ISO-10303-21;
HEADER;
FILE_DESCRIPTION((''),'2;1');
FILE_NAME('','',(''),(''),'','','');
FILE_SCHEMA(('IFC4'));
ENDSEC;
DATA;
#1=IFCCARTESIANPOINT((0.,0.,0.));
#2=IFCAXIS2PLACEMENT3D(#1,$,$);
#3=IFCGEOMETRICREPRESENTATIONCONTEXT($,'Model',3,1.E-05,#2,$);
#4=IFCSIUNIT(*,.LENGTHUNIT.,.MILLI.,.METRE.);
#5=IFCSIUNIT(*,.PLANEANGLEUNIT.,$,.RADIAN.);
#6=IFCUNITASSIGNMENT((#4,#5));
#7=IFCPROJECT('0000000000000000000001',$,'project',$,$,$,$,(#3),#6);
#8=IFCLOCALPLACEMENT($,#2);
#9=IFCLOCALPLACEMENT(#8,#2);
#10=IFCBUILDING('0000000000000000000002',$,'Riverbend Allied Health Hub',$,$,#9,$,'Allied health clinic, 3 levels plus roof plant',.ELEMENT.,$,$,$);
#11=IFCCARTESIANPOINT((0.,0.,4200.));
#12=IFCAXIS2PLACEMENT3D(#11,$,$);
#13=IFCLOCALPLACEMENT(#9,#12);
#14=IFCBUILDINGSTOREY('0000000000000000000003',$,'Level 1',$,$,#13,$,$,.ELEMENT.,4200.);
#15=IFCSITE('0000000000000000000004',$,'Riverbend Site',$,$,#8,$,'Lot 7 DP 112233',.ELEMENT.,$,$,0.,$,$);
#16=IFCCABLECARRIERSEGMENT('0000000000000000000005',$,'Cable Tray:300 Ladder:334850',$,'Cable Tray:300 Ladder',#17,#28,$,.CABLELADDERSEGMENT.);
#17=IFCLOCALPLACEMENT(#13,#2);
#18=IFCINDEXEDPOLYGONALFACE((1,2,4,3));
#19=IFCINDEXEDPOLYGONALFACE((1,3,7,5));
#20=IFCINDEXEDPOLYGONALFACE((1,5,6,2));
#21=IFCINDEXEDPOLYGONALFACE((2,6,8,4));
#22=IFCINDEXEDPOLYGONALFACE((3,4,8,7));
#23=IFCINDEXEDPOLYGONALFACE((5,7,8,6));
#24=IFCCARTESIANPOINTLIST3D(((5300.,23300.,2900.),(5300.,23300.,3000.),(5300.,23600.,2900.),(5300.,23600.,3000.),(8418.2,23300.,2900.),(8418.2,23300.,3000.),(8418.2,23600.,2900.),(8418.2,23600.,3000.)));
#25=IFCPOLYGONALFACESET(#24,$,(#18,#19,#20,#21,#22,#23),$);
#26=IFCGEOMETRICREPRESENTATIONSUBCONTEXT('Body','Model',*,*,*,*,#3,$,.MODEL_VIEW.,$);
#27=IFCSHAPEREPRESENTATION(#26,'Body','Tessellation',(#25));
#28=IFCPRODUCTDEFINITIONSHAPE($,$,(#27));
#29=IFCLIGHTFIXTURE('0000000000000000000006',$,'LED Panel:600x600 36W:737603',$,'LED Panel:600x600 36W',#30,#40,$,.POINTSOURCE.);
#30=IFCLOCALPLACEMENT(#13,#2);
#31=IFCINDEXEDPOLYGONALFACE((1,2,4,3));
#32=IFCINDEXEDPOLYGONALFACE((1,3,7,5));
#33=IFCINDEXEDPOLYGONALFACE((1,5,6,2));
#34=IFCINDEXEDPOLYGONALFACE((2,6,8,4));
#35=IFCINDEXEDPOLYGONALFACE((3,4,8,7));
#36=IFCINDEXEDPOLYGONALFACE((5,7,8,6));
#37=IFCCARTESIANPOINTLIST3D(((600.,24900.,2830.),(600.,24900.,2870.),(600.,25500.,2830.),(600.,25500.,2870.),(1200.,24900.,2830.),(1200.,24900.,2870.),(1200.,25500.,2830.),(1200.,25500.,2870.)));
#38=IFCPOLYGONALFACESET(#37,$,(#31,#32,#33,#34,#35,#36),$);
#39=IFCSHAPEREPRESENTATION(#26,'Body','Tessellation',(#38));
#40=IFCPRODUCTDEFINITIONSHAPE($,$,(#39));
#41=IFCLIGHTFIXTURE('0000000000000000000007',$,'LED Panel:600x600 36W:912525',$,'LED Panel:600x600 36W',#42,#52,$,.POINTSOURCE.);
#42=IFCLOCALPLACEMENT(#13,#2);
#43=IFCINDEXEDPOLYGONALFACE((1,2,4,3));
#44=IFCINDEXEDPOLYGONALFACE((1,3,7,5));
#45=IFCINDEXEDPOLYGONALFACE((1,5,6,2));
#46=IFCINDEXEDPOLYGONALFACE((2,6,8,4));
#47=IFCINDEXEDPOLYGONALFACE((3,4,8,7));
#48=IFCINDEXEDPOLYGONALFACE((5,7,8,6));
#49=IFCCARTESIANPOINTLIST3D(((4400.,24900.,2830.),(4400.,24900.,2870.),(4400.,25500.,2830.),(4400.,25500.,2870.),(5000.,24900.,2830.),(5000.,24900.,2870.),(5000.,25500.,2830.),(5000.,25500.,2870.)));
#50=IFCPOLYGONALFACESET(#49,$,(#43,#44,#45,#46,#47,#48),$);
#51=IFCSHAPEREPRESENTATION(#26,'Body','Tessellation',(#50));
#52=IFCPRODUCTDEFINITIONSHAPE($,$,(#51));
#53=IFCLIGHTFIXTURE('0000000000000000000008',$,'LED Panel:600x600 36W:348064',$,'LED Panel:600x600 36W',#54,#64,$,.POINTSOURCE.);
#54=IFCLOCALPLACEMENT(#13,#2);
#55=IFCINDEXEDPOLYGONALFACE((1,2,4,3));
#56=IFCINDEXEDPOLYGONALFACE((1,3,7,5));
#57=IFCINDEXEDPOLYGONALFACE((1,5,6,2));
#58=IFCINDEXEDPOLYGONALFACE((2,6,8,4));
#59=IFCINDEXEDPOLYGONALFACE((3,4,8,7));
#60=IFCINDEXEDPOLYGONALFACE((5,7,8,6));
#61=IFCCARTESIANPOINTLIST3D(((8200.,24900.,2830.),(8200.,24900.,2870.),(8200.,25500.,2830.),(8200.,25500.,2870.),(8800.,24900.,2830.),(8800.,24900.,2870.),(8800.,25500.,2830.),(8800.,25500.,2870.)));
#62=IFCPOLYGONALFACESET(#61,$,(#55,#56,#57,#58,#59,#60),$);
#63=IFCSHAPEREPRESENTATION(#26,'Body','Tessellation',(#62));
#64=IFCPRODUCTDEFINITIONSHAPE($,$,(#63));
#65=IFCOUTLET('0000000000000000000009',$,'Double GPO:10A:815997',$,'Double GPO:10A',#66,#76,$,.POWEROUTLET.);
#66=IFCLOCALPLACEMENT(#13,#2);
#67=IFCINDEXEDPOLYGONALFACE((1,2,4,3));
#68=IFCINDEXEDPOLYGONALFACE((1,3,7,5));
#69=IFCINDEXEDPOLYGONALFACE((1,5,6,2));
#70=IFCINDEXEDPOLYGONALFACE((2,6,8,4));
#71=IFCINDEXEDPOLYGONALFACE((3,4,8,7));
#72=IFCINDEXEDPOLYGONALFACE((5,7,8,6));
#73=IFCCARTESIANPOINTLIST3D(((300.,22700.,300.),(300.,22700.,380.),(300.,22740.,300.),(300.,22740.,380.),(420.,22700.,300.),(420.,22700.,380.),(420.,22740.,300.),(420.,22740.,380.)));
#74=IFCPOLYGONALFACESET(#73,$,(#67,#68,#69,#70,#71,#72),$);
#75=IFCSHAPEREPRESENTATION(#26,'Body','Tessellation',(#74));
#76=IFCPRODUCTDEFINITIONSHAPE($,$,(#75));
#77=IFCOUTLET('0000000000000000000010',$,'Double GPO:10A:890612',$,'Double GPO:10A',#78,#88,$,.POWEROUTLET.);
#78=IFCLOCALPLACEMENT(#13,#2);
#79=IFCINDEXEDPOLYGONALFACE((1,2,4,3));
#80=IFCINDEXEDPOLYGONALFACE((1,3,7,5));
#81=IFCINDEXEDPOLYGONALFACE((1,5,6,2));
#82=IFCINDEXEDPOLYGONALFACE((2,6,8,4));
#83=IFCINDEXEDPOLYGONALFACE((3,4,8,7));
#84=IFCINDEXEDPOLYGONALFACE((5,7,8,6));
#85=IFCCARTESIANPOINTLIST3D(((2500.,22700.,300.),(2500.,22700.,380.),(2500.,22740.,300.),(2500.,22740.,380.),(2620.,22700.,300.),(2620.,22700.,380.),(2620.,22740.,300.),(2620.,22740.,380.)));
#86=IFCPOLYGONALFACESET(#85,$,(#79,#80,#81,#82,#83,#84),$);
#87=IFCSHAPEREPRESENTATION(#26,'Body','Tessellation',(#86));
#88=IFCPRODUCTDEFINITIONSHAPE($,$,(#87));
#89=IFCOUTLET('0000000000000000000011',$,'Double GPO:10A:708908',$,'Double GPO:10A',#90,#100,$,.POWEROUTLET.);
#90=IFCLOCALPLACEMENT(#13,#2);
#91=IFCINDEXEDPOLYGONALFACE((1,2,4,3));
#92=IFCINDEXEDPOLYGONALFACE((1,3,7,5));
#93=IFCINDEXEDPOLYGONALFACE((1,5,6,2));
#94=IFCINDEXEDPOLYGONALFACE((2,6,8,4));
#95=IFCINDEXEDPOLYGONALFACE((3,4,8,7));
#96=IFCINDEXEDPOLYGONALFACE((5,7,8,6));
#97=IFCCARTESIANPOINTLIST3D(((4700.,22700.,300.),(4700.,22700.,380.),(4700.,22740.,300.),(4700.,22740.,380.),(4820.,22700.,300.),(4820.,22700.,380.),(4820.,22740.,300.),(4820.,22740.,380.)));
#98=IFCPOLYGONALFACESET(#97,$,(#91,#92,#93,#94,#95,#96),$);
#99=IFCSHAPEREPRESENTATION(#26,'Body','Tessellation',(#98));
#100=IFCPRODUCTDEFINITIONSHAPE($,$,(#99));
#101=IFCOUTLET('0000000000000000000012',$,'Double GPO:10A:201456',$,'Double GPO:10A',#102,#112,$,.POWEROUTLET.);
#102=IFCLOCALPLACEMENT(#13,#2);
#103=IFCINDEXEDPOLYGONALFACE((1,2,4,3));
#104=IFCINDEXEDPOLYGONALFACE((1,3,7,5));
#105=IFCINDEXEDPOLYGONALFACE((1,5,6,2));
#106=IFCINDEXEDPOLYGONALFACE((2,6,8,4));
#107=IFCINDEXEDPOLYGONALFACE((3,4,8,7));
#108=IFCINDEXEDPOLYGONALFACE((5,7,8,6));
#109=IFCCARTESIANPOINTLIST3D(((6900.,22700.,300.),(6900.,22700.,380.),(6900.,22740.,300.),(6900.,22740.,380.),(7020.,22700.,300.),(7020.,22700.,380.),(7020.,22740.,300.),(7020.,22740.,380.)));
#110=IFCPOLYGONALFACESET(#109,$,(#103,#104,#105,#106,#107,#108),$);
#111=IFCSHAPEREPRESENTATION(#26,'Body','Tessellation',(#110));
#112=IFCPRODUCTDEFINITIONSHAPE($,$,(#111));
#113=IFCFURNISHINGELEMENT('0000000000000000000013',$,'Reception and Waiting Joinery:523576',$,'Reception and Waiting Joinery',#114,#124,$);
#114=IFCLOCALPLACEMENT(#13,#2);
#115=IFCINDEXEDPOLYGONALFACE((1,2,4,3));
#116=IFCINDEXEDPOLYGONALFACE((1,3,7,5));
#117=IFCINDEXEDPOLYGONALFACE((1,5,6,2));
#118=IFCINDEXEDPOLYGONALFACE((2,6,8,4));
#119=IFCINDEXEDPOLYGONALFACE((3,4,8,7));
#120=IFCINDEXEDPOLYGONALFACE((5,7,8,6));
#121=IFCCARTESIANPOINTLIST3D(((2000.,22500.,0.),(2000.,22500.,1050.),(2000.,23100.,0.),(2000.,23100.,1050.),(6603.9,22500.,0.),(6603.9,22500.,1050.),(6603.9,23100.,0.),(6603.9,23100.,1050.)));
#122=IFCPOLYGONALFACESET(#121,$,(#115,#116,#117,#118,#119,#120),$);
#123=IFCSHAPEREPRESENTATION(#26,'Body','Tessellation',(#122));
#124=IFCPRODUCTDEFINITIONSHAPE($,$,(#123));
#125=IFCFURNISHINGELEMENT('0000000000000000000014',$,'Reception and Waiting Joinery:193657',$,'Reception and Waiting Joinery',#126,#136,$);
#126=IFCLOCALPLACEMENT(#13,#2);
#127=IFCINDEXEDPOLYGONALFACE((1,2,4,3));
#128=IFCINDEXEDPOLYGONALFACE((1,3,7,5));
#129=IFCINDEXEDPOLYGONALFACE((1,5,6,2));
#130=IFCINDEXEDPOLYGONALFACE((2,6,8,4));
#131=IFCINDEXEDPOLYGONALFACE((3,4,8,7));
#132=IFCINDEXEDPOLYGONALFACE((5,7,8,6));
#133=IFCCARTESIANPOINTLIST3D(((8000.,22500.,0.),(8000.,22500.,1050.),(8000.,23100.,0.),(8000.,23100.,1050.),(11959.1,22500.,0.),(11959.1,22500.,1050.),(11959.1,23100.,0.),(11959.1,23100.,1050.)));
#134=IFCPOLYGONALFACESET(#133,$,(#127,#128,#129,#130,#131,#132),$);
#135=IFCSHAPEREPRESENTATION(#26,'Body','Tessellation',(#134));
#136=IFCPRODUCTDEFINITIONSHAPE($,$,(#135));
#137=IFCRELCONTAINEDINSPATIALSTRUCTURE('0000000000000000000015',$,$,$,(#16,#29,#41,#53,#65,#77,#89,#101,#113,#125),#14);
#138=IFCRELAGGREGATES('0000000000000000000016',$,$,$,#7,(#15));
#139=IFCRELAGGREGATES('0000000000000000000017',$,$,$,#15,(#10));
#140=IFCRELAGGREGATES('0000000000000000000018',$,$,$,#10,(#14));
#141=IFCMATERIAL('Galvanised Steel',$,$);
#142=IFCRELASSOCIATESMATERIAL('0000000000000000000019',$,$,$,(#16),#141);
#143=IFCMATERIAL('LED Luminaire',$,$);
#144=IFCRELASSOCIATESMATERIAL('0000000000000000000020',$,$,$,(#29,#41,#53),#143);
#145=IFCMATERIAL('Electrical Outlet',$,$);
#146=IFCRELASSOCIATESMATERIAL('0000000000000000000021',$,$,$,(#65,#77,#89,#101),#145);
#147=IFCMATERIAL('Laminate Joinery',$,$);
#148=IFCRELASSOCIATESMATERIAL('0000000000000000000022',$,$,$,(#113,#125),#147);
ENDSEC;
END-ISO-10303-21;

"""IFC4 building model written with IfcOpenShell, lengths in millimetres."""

from ifc_helpers import new_model, si_unit, frame, frame_2d, origin, place, context, subcontext, project, spatial, rectangle, extrude, material, element, save


model = new_model("IFC4")

# Units and contexts
model_context = context("Model", 3, precision=1e-05, world=origin())
body_context = subcontext(model_context, "Body", "Model", "MODEL_VIEW")
ifc_project = project(units=[si_unit("LENGTHUNIT", "METRE", prefix="MILLI"), si_unit("PLANEANGLEUNIT", "RADIAN")], contexts=[model_context])

# Site, building, storey
site_placement = place(None, origin())
site = spatial("IfcSite", under=ifc_project, at=site_placement, Name="Riverbend Site", LongName="Lot 7 DP 112233", CompositionType="ELEMENT", RefElevation=0.0)
building_placement = place(site_placement, origin())
building = spatial("IfcBuilding", under=site, at=building_placement, Name="Riverbend Allied Health Hub", LongName="Allied health clinic, 3 levels plus roof plant", CompositionType="ELEMENT")
storey_placement = place(building_placement, frame((0.0, 0.0, 4200.0)))
storey = spatial("IfcBuildingStorey", under=building, at=storey_placement, Name="Level 1", CompositionType="ELEMENT", Elevation=4200.0)

# Shared definitions
ifc_material_1 = material(Name="Galvanised Steel")

# Cable carrier segment
cable_carrier_segment_1_placement = place(storey_placement, frame((5300.0, 23300.0, 2900.0)))
element("IfcCableCarrierSegment", 1, at=cable_carrier_segment_1_placement, inside=storey, material=ifc_material_1, Name="Cable Tray:300 Ladder:334850", ObjectType="Cable Tray:300 Ladder", PredefinedType="CABLELADDERSEGMENT", context=body_context, shape_type="SweptSolid", body=[
    extrude(rectangle(XDim=3118.2, YDim=300.0, at=frame_2d((1559.1, 150.0))), origin(), (0.0, 0.0, 1.0), 100.0),
])

# Light fixtures
ifc_material_2 = material(Name="LED Luminaire")
for number, where, name in (
    (2, (600.0, 24900.0, 2830.0), "LED Panel:600x600 36W:737603"),
    (3, (4400.0, 24900.0, 2830.0), "LED Panel:600x600 36W:912525"),
    (4, (8200.0, 24900.0, 2830.0), "LED Panel:600x600 36W:348064"),
):
    element("IfcLightFixture", number, at=place(storey_placement, frame(where)), inside=storey, material=ifc_material_2, Name=name, ObjectType="LED Panel:600x600 36W", PredefinedType="POINTSOURCE", context=body_context, shape_type="SweptSolid", body=[
        extrude(rectangle(XDim=600.0, YDim=600.0, at=frame_2d((300.0, 300.0))), origin(), (0.0, 0.0, 1.0), 40.0),
    ])

# Outlets
ifc_material_3 = material(Name="Electrical Outlet")
for number, where, name in (
    (5, (300.0, 22700.0, 300.0), "Double GPO:10A:815997"),
    (6, (2500.0, 22700.0, 300.0), "Double GPO:10A:890612"),
    (7, (4700.0, 22700.0, 300.0), "Double GPO:10A:708908"),
    (8, (6900.0, 22700.0, 300.0), "Double GPO:10A:201456"),
):
    element("IfcOutlet", number, at=place(storey_placement, frame(where)), inside=storey, material=ifc_material_3, Name=name, ObjectType="Double GPO:10A", PredefinedType="POWEROUTLET", context=body_context, shape_type="SweptSolid", body=[
        extrude(rectangle(XDim=120.0, YDim=40.0, at=frame_2d((60.0, 20.0))), origin(), (0.0, 0.0, 1.0), 80.0),
    ])

# Furnishing elements
ifc_material_4 = material(Name="Laminate Joinery")
furnishing_1_placement = place(storey_placement, frame((2000.0, 22500.0, 0.0)))
element("IfcFurnishingElement", 9, at=furnishing_1_placement, inside=storey, material=ifc_material_4, Name="Reception and Waiting Joinery:523576", ObjectType="Reception and Waiting Joinery", context=body_context, shape_type="SweptSolid", body=[
    extrude(rectangle(XDim=4603.9, YDim=600.0, at=frame_2d((2301.9, 300.0))), origin(), (0.0, 0.0, 1.0), 1050.0),
])
furnishing_2_placement = place(storey_placement, frame((8000.0, 22500.0, 0.0)))
element("IfcFurnishingElement", 10, at=furnishing_2_placement, inside=storey, material=ifc_material_4, Name="Reception and Waiting Joinery:193657", ObjectType="Reception and Waiting Joinery", context=body_context, shape_type="SweptSolid", body=[
    extrude(rectangle(XDim=3959.1, YDim=600.0, at=frame_2d((1979.5, 300.0))), origin(), (0.0, 0.0, 1.0), 1050.0),
])

save(model, "model.ifc")
